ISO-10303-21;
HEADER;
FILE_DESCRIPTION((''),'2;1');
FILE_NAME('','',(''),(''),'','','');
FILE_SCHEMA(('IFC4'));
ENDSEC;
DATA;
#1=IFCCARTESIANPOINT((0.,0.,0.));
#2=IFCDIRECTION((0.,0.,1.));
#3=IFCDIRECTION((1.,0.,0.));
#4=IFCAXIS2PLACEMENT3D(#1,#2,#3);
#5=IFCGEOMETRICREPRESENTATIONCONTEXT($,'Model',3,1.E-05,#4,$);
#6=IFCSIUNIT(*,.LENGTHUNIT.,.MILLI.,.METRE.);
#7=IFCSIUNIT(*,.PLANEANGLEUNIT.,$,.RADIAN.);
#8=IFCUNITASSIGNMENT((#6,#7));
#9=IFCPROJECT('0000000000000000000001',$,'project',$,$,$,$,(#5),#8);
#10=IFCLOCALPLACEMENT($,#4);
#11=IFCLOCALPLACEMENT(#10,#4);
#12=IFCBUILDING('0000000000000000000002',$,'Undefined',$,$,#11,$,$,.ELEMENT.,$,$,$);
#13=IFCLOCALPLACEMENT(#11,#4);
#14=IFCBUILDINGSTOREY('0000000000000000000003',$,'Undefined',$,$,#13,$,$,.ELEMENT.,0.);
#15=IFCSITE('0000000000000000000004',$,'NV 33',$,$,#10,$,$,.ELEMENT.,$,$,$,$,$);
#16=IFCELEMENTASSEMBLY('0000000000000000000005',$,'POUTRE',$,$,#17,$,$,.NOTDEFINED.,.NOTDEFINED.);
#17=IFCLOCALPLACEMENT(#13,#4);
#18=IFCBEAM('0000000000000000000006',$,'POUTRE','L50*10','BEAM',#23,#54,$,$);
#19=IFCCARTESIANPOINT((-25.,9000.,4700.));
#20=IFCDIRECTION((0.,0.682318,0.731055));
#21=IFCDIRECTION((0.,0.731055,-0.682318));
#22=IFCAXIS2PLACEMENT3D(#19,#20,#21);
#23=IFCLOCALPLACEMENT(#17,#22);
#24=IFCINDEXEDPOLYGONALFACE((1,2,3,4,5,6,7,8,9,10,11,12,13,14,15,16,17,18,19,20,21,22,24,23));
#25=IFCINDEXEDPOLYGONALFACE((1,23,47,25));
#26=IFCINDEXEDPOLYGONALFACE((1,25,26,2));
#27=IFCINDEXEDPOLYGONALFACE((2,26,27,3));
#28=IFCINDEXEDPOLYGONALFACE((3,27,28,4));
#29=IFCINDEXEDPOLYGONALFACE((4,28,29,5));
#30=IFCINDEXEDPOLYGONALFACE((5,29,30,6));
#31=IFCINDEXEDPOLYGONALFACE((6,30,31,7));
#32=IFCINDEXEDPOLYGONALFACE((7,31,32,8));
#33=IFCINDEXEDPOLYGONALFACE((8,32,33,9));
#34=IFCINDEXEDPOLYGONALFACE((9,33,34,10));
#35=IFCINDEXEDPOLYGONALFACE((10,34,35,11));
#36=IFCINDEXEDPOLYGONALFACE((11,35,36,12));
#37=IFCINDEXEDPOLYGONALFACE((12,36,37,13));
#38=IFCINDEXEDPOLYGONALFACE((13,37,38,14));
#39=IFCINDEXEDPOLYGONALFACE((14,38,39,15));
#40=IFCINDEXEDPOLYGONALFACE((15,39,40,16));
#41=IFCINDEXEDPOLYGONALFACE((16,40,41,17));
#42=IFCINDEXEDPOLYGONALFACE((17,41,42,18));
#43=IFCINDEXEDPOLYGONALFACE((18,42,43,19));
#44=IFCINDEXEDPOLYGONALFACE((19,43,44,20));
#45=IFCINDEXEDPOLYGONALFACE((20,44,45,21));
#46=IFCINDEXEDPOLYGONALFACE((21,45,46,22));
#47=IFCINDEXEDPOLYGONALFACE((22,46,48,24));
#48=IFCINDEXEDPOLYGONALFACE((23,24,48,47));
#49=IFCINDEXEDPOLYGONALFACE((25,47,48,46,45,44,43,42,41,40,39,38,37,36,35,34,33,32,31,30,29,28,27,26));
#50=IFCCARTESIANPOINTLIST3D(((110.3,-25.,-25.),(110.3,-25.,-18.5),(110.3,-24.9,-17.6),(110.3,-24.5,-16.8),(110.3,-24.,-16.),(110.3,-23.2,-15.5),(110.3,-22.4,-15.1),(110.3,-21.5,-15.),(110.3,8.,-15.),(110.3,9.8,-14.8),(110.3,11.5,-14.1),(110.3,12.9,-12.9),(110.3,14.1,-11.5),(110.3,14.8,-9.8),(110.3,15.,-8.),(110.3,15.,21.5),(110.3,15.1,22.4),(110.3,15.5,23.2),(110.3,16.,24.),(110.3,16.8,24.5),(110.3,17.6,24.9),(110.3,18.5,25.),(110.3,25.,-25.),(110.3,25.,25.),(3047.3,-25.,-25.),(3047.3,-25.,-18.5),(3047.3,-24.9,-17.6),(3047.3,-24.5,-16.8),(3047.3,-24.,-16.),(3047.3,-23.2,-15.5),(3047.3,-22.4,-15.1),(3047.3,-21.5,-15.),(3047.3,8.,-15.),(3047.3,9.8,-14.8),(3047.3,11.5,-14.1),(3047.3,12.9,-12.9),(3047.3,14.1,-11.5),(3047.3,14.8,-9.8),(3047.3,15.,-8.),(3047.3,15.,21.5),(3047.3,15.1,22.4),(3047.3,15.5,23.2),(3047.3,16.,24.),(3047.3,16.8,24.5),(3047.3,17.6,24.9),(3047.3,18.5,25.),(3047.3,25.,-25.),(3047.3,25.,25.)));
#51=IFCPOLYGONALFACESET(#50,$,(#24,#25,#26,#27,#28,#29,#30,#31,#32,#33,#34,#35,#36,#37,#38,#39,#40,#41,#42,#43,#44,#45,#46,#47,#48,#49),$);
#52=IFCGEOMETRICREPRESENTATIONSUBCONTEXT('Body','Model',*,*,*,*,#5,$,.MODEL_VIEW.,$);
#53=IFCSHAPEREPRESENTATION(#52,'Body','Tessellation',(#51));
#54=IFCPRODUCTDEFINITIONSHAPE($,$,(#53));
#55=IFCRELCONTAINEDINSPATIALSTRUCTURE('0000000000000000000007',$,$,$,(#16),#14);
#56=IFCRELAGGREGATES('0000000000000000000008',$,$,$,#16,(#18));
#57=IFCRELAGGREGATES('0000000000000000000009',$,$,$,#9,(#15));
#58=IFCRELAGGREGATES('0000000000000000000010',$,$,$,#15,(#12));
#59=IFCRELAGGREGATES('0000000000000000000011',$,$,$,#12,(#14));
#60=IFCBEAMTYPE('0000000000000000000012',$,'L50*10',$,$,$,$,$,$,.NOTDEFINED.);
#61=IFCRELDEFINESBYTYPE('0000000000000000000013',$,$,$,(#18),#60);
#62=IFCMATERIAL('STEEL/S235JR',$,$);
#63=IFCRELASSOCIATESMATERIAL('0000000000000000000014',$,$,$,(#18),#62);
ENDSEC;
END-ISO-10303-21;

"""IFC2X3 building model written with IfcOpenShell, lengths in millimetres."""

from ifc_helpers import new_model, si_unit, frame, origin_with_axes, origin_2d_with_axis, place, context, subcontext, project, spatial, l_section, extrude, clip, halfspace, material, type_object, element, aggregate, save


model = new_model("IFC2X3")

# Units and contexts
model_context = context("Model", 3, precision=1e-05, world=origin_with_axes())
body_context = subcontext(model_context, "Body", "Model", "MODEL_VIEW")
ifc_project = project(units=[si_unit("LENGTHUNIT", "METRE", prefix="MILLI"), si_unit("PLANEANGLEUNIT", "RADIAN")], contexts=[model_context])

# Site, building, storey
site_placement = place(None, origin_with_axes())
site = spatial("IfcSite", under=ifc_project, at=site_placement, Name="NV 33", CompositionType="ELEMENT")
building_placement = place(site_placement, origin_with_axes())
building = spatial("IfcBuilding", under=site, at=building_placement, Name="Undefined", CompositionType="ELEMENT")
storey_placement = place(building_placement, origin_with_axes())
storey = spatial("IfcBuildingStorey", under=building, at=storey_placement, Name="Undefined", CompositionType="ELEMENT", Elevation=0.0)

# Shared definitions
ifc_material_1 = material(Name="STEEL/S235JR")

# Element assembly, beam
assembly_1_placement = place(storey_placement, origin_with_axes())
assembly_1 = element("IfcElementAssembly", 1, at=assembly_1_placement, inside=storey, Name="POUTRE", AssemblyPlace="NOTDEFINED", PredefinedType="NOTDEFINED")
beam_type_1 = type_object("IfcBeamType", Name="L50*10", PredefinedType="NOTDEFINED")
beam_1_placement = place(assembly_1_placement, frame((-25.0, 9000.0, 4700.0), z_axis=(0.0, 0.682318, 0.731055), x_axis=(0.0, 0.731055, -0.682318)))
beam_1 = element("IfcBeam", 2, at=beam_1_placement, type_object=beam_type_1, material=ifc_material_1, Name="POUTRE", Description="L50*10", ObjectType="BEAM", context=body_context, shape_type="Clipping", body=[
    clip(clip(extrude(l_section(Depth=50.0, Width=50.0, Thickness=10.0, FilletRadius=7.0, EdgeRadius=3.5, at=origin_2d_with_axis()), frame((3097.7, 0.0, 0.0), z_axis=(-1.0, 0.0, 0.0), x_axis=(0.0, -1.0, 0.0)), (0.0, 0.0, 1.0), 3097.7), halfspace(frame((3047.3, 0.0, -25.0), z_axis=(-1.0, 0.0, 0.0), x_axis=(0.0, 1.0, 0.0)), True)), halfspace(frame((110.3, 31.0, 0.0), z_axis=(1.0, 0.0, 0.0), x_axis=(0.0, 0.0, -1.0)), True)),
])
aggregate(assembly_1, [beam_1])

save(model, "model.ifc")
